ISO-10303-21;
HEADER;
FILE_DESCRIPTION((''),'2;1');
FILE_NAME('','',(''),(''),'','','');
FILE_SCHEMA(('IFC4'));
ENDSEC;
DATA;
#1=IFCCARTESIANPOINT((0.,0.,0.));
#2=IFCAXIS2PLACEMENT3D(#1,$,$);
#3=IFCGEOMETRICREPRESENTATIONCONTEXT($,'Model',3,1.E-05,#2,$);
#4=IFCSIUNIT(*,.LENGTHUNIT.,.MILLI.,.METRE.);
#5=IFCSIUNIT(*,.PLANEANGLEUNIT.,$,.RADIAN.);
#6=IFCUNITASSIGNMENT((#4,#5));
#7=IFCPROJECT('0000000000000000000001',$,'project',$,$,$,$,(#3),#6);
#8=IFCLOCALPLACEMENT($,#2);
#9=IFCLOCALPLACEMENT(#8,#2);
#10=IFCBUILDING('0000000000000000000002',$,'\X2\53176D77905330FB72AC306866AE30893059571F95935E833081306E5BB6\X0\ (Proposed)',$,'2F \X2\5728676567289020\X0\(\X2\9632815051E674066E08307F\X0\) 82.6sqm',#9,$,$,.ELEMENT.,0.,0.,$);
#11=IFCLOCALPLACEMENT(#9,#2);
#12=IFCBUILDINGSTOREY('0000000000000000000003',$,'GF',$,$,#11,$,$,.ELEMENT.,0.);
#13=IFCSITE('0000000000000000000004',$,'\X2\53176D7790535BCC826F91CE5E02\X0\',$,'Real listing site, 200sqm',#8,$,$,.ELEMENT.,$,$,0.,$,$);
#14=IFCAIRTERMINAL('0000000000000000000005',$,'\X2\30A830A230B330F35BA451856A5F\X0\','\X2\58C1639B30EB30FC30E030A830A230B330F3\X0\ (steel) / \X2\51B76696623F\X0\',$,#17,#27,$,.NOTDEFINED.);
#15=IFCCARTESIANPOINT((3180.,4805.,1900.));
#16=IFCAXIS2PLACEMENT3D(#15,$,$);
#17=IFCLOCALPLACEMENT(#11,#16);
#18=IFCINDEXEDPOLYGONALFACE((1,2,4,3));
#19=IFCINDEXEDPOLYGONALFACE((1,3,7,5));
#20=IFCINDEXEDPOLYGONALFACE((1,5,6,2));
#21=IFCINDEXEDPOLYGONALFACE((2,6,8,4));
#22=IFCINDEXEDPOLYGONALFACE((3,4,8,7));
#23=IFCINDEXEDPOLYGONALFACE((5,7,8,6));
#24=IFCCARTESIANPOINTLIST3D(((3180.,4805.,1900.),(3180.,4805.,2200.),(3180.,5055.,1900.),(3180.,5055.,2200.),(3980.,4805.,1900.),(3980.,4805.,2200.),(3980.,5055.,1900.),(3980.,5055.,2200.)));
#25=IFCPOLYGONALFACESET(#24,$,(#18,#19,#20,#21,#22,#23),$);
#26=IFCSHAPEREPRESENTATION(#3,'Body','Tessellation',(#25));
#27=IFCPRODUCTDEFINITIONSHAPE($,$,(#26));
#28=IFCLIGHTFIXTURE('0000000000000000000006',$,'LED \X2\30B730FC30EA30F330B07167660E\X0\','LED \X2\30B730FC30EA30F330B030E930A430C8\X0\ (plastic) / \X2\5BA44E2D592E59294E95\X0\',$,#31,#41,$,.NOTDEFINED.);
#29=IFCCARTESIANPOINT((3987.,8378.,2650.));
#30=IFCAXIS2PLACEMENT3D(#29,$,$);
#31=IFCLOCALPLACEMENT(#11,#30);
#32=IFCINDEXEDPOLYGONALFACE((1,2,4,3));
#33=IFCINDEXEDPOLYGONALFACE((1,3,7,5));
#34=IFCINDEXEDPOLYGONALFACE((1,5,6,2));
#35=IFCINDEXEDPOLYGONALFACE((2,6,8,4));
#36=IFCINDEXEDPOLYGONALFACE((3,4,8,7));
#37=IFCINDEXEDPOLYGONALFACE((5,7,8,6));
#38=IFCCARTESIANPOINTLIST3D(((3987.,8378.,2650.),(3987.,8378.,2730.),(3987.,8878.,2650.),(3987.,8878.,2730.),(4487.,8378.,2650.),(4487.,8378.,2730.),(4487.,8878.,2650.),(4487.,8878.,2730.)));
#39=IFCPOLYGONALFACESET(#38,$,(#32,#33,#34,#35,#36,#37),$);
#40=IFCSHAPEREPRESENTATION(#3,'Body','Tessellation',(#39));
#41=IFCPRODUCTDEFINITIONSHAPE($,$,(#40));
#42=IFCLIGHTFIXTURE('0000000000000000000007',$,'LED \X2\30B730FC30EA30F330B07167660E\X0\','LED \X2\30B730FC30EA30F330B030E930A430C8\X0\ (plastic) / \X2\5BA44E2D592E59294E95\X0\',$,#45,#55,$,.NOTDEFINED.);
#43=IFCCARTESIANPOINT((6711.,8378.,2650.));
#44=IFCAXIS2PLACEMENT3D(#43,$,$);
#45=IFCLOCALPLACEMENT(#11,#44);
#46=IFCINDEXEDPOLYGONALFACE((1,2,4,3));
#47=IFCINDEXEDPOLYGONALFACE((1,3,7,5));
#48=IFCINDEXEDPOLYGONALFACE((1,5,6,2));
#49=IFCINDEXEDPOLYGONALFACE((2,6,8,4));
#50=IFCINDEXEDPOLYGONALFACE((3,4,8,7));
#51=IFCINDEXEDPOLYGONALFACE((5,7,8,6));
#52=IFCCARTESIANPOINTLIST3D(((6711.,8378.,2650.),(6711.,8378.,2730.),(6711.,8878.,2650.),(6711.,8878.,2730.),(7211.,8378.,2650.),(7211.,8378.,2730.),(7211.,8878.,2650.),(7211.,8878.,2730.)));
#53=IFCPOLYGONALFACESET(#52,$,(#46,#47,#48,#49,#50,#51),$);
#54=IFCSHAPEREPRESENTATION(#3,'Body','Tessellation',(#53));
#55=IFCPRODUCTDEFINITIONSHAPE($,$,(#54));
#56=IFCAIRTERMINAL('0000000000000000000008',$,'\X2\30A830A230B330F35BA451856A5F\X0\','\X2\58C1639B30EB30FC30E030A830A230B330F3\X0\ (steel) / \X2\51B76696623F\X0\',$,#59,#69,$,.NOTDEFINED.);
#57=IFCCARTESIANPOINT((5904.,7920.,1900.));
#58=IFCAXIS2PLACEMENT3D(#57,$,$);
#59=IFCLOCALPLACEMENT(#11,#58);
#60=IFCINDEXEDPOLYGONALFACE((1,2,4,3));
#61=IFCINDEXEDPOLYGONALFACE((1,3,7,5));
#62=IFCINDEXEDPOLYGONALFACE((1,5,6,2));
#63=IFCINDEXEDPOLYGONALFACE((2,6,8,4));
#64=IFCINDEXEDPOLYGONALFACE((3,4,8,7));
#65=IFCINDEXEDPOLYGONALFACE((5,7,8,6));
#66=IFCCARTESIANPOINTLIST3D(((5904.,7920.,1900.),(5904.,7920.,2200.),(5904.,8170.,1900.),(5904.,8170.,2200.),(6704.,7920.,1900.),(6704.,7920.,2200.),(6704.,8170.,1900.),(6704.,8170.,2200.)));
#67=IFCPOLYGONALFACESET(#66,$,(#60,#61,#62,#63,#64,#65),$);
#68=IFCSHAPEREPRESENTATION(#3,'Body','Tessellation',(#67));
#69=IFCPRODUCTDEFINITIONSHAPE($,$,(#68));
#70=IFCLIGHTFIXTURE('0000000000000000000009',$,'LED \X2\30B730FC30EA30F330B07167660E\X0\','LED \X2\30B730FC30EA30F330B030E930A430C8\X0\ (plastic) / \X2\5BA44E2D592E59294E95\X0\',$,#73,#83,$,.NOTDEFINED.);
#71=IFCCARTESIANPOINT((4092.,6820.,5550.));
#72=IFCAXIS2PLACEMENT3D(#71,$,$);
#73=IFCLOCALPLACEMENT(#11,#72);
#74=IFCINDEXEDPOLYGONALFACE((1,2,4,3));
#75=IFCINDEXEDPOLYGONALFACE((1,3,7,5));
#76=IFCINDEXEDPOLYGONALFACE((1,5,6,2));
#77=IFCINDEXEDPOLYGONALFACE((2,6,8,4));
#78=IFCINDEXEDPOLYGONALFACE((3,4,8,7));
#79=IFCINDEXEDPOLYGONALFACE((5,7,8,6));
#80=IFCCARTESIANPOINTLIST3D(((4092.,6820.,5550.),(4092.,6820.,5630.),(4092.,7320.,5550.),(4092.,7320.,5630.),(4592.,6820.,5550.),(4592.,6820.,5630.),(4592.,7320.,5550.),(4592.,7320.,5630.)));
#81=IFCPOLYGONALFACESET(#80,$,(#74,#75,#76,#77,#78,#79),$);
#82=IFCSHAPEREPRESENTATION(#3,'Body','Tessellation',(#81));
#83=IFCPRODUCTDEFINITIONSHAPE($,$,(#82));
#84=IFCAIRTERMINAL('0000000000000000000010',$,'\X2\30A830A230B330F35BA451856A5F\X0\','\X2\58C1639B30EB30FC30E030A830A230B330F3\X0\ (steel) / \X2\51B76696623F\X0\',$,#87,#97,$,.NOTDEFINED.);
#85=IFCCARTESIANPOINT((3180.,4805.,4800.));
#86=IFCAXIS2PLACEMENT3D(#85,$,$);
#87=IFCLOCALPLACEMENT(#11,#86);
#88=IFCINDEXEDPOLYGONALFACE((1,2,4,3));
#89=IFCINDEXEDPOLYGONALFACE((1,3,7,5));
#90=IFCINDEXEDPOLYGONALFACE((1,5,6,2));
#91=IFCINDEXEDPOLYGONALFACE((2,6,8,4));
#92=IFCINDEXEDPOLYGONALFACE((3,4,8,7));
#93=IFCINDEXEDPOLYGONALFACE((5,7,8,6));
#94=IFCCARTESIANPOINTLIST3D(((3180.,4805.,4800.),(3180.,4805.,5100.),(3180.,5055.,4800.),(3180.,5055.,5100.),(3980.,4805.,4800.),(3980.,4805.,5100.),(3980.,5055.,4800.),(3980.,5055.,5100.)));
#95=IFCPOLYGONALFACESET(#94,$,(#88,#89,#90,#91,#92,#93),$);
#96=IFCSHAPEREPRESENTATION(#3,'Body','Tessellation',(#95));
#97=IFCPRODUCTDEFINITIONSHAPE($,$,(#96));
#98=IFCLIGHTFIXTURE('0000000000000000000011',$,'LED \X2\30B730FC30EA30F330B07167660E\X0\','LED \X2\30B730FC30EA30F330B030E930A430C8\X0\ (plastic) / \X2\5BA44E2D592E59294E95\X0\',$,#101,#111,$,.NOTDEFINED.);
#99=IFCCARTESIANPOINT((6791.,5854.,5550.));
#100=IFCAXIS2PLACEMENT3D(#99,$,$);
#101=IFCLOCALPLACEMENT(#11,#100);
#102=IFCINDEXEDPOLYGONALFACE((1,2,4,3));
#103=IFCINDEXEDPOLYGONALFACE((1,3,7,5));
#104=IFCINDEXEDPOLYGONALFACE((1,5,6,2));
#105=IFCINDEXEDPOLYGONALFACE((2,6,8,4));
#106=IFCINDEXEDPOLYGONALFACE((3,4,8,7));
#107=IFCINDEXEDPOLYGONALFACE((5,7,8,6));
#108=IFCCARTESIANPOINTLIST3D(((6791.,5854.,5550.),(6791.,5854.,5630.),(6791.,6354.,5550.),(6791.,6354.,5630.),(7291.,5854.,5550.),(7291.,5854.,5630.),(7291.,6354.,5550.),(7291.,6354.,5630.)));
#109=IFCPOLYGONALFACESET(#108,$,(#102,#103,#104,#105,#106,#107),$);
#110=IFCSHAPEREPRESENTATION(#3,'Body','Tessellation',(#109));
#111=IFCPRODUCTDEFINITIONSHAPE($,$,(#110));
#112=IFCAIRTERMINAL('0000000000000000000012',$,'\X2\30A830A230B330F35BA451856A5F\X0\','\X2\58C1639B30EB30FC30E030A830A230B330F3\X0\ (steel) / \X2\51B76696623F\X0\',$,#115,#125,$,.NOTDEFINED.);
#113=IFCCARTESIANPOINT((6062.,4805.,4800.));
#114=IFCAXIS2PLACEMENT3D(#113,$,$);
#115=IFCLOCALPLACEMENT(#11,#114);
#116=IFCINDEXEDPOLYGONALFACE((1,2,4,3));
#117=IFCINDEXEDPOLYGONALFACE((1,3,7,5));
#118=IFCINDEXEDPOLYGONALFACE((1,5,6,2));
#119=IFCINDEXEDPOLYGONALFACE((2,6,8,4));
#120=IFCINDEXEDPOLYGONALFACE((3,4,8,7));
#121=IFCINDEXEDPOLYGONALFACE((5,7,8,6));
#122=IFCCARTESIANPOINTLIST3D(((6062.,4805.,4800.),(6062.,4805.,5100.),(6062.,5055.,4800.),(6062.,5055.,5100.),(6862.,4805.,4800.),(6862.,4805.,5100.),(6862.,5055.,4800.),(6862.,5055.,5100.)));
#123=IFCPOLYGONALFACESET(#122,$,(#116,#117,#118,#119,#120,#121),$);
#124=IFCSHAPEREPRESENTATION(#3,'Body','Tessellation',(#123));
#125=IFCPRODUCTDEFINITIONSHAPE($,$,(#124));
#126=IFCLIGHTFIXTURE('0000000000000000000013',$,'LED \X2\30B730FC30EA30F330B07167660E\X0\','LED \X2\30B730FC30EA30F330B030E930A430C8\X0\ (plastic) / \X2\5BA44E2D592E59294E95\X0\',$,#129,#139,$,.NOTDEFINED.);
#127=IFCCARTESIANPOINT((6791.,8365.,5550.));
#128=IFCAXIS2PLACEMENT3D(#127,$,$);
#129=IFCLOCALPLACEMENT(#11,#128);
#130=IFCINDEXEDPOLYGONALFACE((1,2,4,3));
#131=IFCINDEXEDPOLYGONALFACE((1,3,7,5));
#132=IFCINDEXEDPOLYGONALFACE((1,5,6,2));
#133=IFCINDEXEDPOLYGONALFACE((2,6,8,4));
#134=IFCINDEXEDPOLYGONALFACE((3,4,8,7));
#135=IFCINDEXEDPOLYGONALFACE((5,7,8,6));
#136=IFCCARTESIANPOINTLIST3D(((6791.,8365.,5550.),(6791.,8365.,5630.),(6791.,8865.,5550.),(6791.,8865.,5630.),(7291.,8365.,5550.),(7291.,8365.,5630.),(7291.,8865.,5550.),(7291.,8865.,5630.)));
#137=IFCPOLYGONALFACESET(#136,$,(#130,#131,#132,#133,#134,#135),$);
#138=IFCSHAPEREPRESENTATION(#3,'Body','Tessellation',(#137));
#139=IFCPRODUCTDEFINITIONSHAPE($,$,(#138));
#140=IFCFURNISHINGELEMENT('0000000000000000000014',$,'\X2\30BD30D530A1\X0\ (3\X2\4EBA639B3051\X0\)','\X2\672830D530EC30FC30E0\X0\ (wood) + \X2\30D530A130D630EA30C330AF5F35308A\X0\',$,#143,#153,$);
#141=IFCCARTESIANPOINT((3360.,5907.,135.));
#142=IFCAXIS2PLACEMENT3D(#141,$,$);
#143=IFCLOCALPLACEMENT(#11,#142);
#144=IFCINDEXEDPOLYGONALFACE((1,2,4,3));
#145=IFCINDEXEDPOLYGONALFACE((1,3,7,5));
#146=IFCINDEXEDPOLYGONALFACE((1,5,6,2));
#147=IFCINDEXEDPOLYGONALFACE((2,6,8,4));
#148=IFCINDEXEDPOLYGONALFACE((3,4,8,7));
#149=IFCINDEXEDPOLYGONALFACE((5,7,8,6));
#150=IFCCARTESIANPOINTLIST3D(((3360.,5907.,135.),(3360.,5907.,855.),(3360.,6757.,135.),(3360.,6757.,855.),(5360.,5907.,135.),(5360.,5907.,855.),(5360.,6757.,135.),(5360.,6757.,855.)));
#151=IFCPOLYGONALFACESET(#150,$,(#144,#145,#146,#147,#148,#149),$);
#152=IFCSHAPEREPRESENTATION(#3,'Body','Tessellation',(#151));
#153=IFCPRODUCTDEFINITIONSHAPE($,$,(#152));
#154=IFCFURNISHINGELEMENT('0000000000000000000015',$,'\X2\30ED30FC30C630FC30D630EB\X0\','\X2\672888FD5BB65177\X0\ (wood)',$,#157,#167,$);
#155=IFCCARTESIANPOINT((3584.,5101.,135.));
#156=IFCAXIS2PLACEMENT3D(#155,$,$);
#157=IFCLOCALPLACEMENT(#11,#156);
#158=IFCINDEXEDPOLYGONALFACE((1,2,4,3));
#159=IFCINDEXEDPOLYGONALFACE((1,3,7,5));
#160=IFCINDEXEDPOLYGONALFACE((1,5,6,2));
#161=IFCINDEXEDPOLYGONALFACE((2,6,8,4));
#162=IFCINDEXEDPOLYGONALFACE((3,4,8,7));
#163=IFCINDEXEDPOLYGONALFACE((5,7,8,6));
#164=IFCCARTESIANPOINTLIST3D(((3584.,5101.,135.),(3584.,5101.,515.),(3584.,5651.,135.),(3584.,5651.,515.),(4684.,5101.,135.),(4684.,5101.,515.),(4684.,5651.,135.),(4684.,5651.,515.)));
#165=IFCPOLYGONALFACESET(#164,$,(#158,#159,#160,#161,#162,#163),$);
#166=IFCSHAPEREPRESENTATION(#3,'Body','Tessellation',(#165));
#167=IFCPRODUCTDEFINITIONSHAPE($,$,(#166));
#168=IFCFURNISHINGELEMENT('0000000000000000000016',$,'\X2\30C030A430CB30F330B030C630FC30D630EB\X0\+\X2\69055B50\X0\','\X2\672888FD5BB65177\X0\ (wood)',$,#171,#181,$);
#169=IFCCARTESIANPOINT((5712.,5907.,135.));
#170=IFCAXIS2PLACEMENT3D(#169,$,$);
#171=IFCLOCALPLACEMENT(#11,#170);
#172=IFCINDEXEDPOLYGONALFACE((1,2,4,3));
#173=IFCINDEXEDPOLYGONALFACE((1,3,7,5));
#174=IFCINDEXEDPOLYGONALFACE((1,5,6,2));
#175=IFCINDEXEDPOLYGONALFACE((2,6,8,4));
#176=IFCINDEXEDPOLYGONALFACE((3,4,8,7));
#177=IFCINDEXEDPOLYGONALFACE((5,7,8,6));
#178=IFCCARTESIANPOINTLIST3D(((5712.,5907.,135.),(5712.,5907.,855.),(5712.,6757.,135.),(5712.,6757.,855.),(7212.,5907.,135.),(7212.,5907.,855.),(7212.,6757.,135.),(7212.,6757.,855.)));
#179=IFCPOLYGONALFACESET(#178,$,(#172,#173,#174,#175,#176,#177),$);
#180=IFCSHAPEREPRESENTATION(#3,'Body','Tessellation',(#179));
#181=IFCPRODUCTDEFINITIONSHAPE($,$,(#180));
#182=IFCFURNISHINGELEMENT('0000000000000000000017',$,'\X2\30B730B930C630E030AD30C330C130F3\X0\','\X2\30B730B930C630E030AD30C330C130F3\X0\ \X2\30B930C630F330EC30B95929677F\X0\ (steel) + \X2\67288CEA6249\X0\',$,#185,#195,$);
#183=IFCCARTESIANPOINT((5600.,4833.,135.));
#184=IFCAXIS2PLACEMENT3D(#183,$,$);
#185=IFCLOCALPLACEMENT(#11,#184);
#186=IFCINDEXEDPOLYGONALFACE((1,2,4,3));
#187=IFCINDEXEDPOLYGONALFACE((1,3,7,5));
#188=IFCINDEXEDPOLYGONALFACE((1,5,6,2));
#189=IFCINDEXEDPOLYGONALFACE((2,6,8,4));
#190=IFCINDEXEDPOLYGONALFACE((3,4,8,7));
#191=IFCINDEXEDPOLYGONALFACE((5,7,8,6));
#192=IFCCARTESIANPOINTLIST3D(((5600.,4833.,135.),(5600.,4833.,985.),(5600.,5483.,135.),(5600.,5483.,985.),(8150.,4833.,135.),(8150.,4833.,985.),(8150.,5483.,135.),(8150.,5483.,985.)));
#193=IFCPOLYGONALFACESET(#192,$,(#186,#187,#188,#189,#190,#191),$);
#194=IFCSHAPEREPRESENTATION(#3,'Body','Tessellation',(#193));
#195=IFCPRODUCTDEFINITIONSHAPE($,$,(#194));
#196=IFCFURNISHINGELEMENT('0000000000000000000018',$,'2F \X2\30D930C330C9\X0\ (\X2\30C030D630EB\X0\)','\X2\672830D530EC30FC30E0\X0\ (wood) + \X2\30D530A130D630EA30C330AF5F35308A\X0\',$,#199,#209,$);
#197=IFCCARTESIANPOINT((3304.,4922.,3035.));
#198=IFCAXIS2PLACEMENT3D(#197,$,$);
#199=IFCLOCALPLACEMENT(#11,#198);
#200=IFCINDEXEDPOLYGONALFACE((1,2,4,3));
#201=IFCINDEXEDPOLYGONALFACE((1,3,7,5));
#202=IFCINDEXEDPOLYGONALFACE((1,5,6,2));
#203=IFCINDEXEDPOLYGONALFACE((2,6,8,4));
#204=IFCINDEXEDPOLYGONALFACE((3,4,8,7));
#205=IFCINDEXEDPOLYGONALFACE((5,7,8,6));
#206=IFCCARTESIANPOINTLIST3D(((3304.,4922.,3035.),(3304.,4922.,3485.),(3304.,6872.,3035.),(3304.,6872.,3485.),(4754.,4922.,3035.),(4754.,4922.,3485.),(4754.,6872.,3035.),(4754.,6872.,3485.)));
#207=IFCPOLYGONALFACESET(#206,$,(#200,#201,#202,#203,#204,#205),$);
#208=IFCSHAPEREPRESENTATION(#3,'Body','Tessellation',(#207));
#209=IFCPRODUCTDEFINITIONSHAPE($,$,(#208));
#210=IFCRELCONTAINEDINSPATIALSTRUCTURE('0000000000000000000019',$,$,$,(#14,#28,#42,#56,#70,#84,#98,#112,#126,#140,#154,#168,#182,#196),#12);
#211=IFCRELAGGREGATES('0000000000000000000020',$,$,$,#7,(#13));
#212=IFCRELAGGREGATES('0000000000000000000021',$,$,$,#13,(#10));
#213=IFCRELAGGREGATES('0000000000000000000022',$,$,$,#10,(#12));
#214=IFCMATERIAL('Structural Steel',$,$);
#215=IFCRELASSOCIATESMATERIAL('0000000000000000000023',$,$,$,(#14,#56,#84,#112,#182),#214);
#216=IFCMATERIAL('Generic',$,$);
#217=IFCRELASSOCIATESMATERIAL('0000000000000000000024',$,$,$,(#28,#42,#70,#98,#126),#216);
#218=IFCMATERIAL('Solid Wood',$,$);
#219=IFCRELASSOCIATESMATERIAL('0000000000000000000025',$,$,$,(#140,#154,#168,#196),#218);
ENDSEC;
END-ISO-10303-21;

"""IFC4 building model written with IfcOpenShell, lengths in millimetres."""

from ifc_helpers import new_model, si_unit, frame, frame_2d, origin, place, context, project, spatial, rectangle, extrude, material, element, save


model = new_model("IFC4")

# Units and contexts
model_context = context("Model", 3, precision=1e-05, world=origin())
ifc_project = project(units=[si_unit("LENGTHUNIT", "METRE", prefix="MILLI"), si_unit("PLANEANGLEUNIT", "RADIAN")], contexts=[model_context])

# Site, building, storey
site_placement = place(None, origin())
site = spatial("IfcSite", under=ifc_project, at=site_placement, Name="北海道富良野市", ObjectType="Real listing site, 200sqm", CompositionType="ELEMENT", RefElevation=0.0)
building_placement = place(site_placement, origin())
building = spatial("IfcBuilding", under=site, at=building_placement, Name="北海道・犬と暮らす土間広めの家 (Proposed)", ObjectType="2F 在来木造(防腐処理済み) 82.6sqm", CompositionType="ELEMENT", ElevationOfRefHeight=0.0, ElevationOfTerrain=0.0)
storey_placement = place(building_placement, origin())
storey = spatial("IfcBuildingStorey", under=building, at=storey_placement, Name="GF", CompositionType="ELEMENT", Elevation=0.0)

# Shared definitions
ifc_material_1 = material(Name="Solid Wood")

# Shared definitions
ifc_material_2 = material(Name="Structural Steel")

# Shared definitions
ifc_material_3 = material(Name="Generic")

# Air terminal
air_terminal_1_placement = place(storey_placement, frame((3180.0, 4805.0, 1900.0)))
element("IfcAirTerminal", 1, at=air_terminal_1_placement, inside=storey, material=ifc_material_2, Name="エアコン室内機", Description="壁掛ルームエアコン (steel) / 冷暖房", PredefinedType="NOTDEFINED", context=model_context, shape_type="SweptSolid", body=[
    extrude(rectangle(XDim=800.0, YDim=250.0, at=frame_2d((400.0, 125.0))), frame((3180.0, 4805.0, 1900.0)), (0.0, 0.0, 1.0), 300.0),
])

# Light fixtures
light_fixture_1_placement = place(storey_placement, frame((3987.0, 8378.0, 2650.0)))
element("IfcLightFixture", 2, at=light_fixture_1_placement, inside=storey, material=ifc_material_3, Name="LED シーリング照明", Description="LED シーリングライト (plastic) / 室中央天井", PredefinedType="NOTDEFINED", context=model_context, shape_type="SweptSolid", body=[
    extrude(rectangle(XDim=500.0, YDim=500.0, at=frame_2d((250.0, 250.0))), frame((3987.0, 8378.0, 2650.0)), (0.0, 0.0, 1.0), 80.0),
])
light_fixture_2_placement = place(storey_placement, frame((6711.0, 8378.0, 2650.0)))
element("IfcLightFixture", 3, at=light_fixture_2_placement, inside=storey, material=ifc_material_3, Name="LED シーリング照明", Description="LED シーリングライト (plastic) / 室中央天井", PredefinedType="NOTDEFINED", context=model_context, shape_type="SweptSolid", body=[
    extrude(rectangle(XDim=500.0, YDim=500.0, at=frame_2d((250.0, 250.0))), frame((6711.0, 8378.0, 2650.0)), (0.0, 0.0, 1.0), 80.0),
])

# Air terminal
air_terminal_2_placement = place(storey_placement, frame((5904.0, 7920.0, 1900.0)))
element("IfcAirTerminal", 4, at=air_terminal_2_placement, inside=storey, material=ifc_material_2, Name="エアコン室内機", Description="壁掛ルームエアコン (steel) / 冷暖房", PredefinedType="NOTDEFINED", context=model_context, shape_type="SweptSolid", body=[
    extrude(rectangle(XDim=800.0, YDim=250.0, at=frame_2d((400.0, 125.0))), frame((5904.0, 7920.0, 1900.0)), (0.0, 0.0, 1.0), 300.0),
])

# Light fixture
light_fixture_3_placement = place(storey_placement, frame((4092.0, 6820.0, 5550.0)))
element("IfcLightFixture", 5, at=light_fixture_3_placement, inside=storey, material=ifc_material_3, Name="LED シーリング照明", Description="LED シーリングライト (plastic) / 室中央天井", PredefinedType="NOTDEFINED", context=model_context, shape_type="SweptSolid", body=[
    extrude(rectangle(XDim=500.0, YDim=500.0, at=frame_2d((250.0, 250.0))), frame((4092.0, 6820.0, 5550.0)), (0.0, 0.0, 1.0), 80.0),
])

# Air terminal
air_terminal_3_placement = place(storey_placement, frame((3180.0, 4805.0, 4800.0)))
element("IfcAirTerminal", 6, at=air_terminal_3_placement, inside=storey, material=ifc_material_2, Name="エアコン室内機", Description="壁掛ルームエアコン (steel) / 冷暖房", PredefinedType="NOTDEFINED", context=model_context, shape_type="SweptSolid", body=[
    extrude(rectangle(XDim=800.0, YDim=250.0, at=frame_2d((400.0, 125.0))), frame((3180.0, 4805.0, 4800.0)), (0.0, 0.0, 1.0), 300.0),
])

# Light fixture
light_fixture_4_placement = place(storey_placement, frame((6791.0, 5854.0, 5550.0)))
element("IfcLightFixture", 7, at=light_fixture_4_placement, inside=storey, material=ifc_material_3, Name="LED シーリング照明", Description="LED シーリングライト (plastic) / 室中央天井", PredefinedType="NOTDEFINED", context=model_context, shape_type="SweptSolid", body=[
    extrude(rectangle(XDim=500.0, YDim=500.0, at=frame_2d((250.0, 250.0))), frame((6791.0, 5854.0, 5550.0)), (0.0, 0.0, 1.0), 80.0),
])

# Air terminal
air_terminal_4_placement = place(storey_placement, frame((6062.0, 4805.0, 4800.0)))
element("IfcAirTerminal", 8, at=air_terminal_4_placement, inside=storey, material=ifc_material_2, Name="エアコン室内機", Description="壁掛ルームエアコン (steel) / 冷暖房", PredefinedType="NOTDEFINED", context=model_context, shape_type="SweptSolid", body=[
    extrude(rectangle(XDim=800.0, YDim=250.0, at=frame_2d((400.0, 125.0))), frame((6062.0, 4805.0, 4800.0)), (0.0, 0.0, 1.0), 300.0),
])

# Light fixture
light_fixture_5_placement = place(storey_placement, frame((6791.0, 8365.0, 5550.0)))
element("IfcLightFixture", 9, at=light_fixture_5_placement, inside=storey, material=ifc_material_3, Name="LED シーリング照明", Description="LED シーリングライト (plastic) / 室中央天井", PredefinedType="NOTDEFINED", context=model_context, shape_type="SweptSolid", body=[
    extrude(rectangle(XDim=500.0, YDim=500.0, at=frame_2d((250.0, 250.0))), frame((6791.0, 8365.0, 5550.0)), (0.0, 0.0, 1.0), 80.0),
])

# Furnishing elements
furnishing_1_placement = place(storey_placement, frame((3360.0, 5907.0, 135.0)))
element("IfcFurnishingElement", 10, at=furnishing_1_placement, inside=storey, material=ifc_material_1, Name="ソファ (3人掛け)", Description="木フレーム (wood) + ファブリック張り", context=model_context, shape_type="SweptSolid", body=[
    extrude(rectangle(XDim=2000.0, YDim=850.0, at=frame_2d((1000.0, 425.0))), frame((3360.0, 5907.0, 135.0)), (0.0, 0.0, 1.0), 720.0),
])
furnishing_2_placement = place(storey_placement, frame((3584.0, 5101.0, 135.0)))
element("IfcFurnishingElement", 11, at=furnishing_2_placement, inside=storey, material=ifc_material_1, Name="ローテーブル", Description="木製家具 (wood)", context=model_context, shape_type="SweptSolid", body=[
    extrude(rectangle(XDim=1100.0, YDim=550.0, at=frame_2d((550.0, 275.0))), frame((3584.0, 5101.0, 135.0)), (0.0, 0.0, 1.0), 380.0),
])
furnishing_3_placement = place(storey_placement, frame((5712.0, 5907.0, 135.0)))
element("IfcFurnishingElement", 12, at=furnishing_3_placement, inside=storey, material=ifc_material_1, Name="ダイニングテーブル+椅子", Description="木製家具 (wood)", context=model_context, shape_type="SweptSolid", body=[
    extrude(rectangle(XDim=1500.0, YDim=850.0, at=frame_2d((750.0, 425.0))), frame((5712.0, 5907.0, 135.0)), (0.0, 0.0, 1.0), 720.0),
])
furnishing_4_placement = place(storey_placement, frame((5600.0, 4833.0, 135.0)))
element("IfcFurnishingElement", 13, at=furnishing_4_placement, inside=storey, material=ifc_material_2, Name="システムキッチン", Description="システムキッチン ステンレス天板 (steel) + 木質扉", context=model_context, shape_type="SweptSolid", body=[
    extrude(rectangle(XDim=2550.0, YDim=650.0, at=frame_2d((1275.0, 325.0))), frame((5600.0, 4833.0, 135.0)), (0.0, 0.0, 1.0), 850.0),
])
furnishing_5_placement = place(storey_placement, frame((3304.0, 4922.0, 3035.0)))
element("IfcFurnishingElement", 14, at=furnishing_5_placement, inside=storey, material=ifc_material_1, Name="2F ベッド (ダブル)", Description="木フレーム (wood) + ファブリック張り", context=model_context, shape_type="SweptSolid", body=[
    extrude(rectangle(XDim=1450.0, YDim=1950.0, at=frame_2d((725.0, 975.0))), frame((3304.0, 4922.0, 3035.0)), (0.0, 0.0, 1.0), 450.0),
])

save(model, "model.ifc")
